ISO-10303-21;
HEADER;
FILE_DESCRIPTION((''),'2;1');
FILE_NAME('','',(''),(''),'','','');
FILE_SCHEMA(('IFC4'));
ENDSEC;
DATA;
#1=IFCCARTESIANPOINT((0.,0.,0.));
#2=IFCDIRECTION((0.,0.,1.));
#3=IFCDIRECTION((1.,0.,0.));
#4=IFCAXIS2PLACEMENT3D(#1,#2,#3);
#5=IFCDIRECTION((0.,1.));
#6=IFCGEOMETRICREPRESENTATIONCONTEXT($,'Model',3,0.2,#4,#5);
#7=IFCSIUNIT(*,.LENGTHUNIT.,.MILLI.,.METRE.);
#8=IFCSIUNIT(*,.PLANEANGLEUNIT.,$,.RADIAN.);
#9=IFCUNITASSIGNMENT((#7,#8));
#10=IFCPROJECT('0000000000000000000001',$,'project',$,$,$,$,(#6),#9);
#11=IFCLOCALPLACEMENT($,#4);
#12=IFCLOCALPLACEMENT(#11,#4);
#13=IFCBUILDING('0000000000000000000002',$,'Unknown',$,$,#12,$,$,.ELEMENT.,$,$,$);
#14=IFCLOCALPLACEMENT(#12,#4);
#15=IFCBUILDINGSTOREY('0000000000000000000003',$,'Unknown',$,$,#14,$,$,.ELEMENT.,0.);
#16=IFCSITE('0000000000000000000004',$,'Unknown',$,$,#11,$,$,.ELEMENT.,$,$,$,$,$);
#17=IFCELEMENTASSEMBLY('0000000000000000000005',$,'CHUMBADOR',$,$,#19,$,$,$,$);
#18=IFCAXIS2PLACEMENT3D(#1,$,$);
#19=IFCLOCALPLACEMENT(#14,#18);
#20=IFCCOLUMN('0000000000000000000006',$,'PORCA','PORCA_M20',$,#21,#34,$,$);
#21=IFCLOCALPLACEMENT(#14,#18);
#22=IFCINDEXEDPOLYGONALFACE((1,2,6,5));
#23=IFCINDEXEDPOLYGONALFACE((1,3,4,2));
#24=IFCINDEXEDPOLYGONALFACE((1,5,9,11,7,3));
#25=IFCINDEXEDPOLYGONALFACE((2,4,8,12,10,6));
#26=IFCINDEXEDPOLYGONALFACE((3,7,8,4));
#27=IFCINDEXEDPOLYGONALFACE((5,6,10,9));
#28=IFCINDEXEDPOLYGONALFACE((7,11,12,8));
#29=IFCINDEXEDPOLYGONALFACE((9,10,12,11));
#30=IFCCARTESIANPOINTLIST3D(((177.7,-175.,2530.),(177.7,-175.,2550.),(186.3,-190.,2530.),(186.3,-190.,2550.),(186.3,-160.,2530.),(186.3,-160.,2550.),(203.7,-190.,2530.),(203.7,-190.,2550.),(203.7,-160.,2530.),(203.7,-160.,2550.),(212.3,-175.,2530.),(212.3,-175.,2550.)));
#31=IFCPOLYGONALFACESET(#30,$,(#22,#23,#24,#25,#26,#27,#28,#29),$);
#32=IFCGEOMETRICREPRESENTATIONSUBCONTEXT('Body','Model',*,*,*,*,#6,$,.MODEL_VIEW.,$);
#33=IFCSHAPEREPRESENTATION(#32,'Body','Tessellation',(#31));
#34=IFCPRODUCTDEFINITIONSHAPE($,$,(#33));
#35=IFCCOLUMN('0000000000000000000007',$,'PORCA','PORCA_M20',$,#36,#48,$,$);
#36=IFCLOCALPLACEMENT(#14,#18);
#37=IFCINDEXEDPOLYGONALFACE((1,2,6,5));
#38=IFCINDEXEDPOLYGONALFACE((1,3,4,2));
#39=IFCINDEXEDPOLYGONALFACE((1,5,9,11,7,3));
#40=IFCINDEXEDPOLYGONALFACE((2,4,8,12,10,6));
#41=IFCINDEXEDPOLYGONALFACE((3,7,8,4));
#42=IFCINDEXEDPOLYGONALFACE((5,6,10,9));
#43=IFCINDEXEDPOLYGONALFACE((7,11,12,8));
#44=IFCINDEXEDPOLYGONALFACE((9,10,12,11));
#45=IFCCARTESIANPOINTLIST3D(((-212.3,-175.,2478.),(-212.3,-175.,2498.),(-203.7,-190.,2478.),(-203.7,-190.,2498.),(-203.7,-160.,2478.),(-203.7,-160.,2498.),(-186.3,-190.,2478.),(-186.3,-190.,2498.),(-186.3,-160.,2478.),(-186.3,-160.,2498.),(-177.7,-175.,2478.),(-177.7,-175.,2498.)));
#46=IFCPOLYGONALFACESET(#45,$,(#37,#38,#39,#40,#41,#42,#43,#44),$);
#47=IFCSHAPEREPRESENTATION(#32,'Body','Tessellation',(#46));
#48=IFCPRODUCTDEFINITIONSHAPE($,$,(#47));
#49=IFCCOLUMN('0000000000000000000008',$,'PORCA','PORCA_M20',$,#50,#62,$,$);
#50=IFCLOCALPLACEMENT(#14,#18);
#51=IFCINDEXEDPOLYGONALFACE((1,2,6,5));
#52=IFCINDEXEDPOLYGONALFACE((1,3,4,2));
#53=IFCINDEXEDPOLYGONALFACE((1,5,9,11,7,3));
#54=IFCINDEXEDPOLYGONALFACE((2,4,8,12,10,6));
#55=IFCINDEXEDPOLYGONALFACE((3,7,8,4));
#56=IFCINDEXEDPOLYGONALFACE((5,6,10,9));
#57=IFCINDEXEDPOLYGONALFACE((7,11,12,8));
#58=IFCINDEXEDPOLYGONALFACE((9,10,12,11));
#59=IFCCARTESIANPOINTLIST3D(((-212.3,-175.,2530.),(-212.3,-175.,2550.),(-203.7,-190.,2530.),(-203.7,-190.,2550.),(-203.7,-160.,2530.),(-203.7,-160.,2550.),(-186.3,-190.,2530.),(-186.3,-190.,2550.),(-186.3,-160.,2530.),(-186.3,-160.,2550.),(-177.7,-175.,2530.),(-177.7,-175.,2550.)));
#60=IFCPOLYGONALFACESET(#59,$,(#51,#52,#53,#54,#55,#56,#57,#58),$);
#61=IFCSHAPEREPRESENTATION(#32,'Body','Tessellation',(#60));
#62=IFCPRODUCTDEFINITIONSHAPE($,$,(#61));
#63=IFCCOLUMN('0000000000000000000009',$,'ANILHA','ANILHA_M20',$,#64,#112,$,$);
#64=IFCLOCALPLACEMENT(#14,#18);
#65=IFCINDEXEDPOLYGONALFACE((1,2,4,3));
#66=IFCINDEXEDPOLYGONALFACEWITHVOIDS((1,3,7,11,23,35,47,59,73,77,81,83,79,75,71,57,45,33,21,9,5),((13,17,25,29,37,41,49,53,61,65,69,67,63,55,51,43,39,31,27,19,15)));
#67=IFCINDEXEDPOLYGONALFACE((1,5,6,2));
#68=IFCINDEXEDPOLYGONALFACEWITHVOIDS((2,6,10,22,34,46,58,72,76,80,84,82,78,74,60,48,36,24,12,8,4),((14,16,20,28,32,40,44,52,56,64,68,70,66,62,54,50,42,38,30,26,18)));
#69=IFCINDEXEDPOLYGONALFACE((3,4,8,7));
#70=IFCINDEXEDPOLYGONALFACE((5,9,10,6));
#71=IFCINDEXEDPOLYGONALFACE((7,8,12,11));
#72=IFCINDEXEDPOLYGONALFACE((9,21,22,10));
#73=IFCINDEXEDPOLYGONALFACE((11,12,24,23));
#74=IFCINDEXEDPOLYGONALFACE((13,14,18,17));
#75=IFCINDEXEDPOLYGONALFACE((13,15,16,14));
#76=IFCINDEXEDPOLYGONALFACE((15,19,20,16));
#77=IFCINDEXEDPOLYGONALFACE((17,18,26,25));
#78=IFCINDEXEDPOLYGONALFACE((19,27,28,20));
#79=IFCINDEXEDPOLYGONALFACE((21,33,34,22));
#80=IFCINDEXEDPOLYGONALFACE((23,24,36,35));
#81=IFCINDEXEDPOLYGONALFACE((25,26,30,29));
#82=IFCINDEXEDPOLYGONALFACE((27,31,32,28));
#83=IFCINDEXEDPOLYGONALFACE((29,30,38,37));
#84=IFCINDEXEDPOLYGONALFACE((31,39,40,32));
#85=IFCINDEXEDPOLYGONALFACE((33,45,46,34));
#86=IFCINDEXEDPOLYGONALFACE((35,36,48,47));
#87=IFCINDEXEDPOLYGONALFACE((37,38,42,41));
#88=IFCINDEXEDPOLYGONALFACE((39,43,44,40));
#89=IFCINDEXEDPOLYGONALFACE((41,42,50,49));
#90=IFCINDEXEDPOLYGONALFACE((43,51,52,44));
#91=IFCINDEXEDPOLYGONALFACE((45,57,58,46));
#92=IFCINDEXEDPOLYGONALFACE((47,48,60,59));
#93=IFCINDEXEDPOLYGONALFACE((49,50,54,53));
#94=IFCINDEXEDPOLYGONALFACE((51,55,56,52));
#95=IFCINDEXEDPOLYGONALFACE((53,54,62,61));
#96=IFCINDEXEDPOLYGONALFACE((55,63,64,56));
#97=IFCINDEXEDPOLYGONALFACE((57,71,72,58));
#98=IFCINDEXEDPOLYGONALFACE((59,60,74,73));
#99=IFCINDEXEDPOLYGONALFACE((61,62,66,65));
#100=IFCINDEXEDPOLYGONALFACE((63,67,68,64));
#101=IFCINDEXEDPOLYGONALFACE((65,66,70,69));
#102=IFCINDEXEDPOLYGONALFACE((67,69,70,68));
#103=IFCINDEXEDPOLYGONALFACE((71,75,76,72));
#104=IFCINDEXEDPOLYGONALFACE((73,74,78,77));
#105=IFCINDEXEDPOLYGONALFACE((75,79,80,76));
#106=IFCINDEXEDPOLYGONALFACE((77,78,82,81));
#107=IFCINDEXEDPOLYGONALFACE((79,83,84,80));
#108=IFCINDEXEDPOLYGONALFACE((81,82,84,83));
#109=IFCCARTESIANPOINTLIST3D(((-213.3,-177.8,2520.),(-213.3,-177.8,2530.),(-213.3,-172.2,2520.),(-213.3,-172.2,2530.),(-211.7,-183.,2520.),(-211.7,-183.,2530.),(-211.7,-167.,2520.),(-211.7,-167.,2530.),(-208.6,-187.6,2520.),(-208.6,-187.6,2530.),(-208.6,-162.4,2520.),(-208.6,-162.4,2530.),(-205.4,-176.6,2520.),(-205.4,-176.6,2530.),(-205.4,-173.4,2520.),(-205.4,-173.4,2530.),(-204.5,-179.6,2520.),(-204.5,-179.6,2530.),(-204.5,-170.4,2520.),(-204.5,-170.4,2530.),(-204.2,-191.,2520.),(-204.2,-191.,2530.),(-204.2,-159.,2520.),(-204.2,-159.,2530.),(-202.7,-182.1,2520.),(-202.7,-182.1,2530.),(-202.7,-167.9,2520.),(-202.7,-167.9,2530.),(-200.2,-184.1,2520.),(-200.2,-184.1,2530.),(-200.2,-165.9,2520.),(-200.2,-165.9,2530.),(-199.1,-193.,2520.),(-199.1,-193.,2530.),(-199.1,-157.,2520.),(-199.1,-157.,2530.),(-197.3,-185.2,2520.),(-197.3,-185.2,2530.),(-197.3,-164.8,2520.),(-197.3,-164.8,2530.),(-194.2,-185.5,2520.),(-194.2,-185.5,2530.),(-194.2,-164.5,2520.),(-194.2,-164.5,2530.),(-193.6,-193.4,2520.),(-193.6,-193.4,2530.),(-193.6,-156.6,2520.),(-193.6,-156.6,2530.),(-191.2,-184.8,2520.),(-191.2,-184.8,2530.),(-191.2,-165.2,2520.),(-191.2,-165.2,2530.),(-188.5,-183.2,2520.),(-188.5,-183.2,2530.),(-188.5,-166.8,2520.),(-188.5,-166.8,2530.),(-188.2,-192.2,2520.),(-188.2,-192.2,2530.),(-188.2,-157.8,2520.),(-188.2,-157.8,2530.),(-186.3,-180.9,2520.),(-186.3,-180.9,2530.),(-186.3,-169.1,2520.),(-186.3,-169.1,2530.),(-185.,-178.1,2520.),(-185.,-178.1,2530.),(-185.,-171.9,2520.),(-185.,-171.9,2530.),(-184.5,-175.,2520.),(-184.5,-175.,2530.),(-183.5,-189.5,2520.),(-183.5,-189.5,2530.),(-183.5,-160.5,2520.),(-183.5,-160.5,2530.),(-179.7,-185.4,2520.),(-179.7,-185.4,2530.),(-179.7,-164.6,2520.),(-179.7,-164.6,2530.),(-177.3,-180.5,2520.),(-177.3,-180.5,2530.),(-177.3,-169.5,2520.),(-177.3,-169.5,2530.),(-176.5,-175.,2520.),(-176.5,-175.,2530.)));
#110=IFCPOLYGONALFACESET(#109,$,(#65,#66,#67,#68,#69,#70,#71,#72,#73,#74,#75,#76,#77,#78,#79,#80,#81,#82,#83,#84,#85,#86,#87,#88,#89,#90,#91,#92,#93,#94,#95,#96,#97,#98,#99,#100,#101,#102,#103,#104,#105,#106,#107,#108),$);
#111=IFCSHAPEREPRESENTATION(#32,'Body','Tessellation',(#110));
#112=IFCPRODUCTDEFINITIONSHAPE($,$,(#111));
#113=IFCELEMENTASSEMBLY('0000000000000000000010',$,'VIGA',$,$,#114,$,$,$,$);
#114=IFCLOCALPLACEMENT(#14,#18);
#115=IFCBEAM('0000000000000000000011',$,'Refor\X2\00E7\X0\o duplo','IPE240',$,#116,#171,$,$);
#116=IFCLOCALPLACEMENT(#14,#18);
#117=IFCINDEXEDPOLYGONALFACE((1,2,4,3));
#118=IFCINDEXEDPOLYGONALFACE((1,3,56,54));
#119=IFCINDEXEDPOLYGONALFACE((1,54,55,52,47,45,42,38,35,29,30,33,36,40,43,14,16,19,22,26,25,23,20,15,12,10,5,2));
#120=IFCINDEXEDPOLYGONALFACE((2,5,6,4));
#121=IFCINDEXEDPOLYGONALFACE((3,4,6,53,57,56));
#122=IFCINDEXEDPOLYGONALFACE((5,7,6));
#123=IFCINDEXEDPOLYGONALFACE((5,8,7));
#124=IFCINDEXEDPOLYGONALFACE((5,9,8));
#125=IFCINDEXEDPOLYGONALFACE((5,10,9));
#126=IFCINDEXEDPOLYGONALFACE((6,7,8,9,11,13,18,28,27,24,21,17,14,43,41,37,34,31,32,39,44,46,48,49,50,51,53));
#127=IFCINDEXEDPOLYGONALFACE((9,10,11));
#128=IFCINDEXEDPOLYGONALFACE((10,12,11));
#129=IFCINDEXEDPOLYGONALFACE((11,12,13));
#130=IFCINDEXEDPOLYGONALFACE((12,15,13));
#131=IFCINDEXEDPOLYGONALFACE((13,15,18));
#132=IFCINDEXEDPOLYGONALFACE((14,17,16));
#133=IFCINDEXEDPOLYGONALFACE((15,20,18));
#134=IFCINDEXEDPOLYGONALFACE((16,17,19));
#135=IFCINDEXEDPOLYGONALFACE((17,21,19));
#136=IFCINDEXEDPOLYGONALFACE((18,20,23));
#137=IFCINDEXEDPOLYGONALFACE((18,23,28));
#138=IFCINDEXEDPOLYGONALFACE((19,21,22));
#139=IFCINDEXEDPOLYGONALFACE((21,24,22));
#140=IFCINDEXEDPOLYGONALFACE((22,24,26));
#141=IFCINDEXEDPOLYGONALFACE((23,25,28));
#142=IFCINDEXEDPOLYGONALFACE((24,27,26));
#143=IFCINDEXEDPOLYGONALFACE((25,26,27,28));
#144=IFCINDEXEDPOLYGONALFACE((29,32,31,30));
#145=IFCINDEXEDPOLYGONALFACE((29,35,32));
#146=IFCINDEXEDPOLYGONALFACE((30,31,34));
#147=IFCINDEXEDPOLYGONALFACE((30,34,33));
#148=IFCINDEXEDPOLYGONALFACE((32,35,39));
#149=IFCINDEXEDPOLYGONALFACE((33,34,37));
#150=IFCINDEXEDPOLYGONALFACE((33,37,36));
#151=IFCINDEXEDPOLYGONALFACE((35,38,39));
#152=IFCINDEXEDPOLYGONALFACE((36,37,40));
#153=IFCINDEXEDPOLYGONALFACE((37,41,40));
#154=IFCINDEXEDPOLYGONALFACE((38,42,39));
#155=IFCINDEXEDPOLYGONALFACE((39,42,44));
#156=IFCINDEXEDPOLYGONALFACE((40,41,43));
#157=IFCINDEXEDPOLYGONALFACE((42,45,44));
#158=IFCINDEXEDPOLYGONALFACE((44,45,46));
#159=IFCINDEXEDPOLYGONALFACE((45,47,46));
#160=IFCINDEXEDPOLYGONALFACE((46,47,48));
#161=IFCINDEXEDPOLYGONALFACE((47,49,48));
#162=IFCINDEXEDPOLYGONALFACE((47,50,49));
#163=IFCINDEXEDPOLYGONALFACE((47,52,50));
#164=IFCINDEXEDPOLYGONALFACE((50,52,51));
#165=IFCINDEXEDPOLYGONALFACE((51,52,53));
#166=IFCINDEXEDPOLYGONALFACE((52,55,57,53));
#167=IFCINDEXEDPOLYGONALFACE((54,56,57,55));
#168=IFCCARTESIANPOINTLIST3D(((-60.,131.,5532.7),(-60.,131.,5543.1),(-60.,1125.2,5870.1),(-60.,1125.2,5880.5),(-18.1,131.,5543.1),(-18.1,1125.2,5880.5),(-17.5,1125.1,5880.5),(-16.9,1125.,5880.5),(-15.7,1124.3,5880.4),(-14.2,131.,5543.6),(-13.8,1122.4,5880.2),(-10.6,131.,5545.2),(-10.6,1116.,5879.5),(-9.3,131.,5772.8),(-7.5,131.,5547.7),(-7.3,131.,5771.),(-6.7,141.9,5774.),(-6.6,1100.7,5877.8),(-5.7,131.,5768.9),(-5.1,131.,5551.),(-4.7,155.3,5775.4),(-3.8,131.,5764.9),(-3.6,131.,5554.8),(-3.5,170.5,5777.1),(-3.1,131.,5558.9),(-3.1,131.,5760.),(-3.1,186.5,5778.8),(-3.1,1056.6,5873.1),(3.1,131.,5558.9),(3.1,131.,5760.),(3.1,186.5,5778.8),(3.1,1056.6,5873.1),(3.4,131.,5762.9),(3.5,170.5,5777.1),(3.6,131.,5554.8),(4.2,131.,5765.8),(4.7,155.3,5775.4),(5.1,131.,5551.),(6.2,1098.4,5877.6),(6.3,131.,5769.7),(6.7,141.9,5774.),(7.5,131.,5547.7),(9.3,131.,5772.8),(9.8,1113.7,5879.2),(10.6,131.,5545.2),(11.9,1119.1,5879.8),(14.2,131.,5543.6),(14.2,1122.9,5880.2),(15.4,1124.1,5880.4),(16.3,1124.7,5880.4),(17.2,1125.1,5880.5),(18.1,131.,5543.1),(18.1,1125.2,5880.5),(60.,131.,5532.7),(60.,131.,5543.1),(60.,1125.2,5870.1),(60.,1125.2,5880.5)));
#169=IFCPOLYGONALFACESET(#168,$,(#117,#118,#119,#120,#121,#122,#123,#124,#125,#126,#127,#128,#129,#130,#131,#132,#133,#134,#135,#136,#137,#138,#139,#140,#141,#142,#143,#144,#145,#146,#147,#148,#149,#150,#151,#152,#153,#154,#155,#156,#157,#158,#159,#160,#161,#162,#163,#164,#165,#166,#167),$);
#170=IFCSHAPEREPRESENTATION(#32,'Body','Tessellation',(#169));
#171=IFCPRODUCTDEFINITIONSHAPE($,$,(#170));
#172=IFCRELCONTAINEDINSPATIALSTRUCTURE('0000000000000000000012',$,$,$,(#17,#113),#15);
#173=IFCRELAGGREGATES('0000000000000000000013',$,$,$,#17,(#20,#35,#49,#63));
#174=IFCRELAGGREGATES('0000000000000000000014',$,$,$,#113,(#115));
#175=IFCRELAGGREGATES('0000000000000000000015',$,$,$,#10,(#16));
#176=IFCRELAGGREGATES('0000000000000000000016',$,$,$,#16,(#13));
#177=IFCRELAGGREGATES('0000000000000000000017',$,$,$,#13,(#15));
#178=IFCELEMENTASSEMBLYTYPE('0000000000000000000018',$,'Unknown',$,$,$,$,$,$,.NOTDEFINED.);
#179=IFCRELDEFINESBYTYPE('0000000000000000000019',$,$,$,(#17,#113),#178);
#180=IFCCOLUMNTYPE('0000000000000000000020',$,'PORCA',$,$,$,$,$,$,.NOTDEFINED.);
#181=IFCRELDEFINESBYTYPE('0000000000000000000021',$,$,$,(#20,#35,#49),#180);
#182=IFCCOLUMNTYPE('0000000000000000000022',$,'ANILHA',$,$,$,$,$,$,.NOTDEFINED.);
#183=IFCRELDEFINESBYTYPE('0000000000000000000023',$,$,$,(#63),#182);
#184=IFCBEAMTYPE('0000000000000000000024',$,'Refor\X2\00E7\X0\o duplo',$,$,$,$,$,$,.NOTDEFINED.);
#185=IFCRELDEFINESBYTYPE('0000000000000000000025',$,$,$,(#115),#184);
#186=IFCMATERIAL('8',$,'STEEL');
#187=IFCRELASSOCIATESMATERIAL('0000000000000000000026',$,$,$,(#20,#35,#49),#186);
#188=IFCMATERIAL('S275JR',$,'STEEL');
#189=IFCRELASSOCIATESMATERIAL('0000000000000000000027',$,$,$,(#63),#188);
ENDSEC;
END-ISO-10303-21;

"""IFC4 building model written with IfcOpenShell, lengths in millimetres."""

from ifc_helpers import new_model, si_unit, direction, frame, origin_with_axes, origin_2d_with_axis, place, context, subcontext, project, spatial, polyline, hollow_circle, i_section, outline, extrude, clip, halfspace, material, material_profile, profile_set, profile_usage, type_object, element, aggregate, save


model = new_model("IFC4")

# Units and contexts
model_context = context("Model", 3, precision=0.2, world=origin_with_axes(), true_north=direction((0.0, 1.0)))
body_context = subcontext(model_context, "Body", "Model", "MODEL_VIEW")
ifc_project = project(units=[si_unit("LENGTHUNIT", "METRE", prefix="MILLI"), si_unit("PLANEANGLEUNIT", "RADIAN")], contexts=[model_context])

# Site, building, storey
site_placement = place(None, origin_with_axes())
site = spatial("IfcSite", under=ifc_project, at=site_placement, Name="Unknown", CompositionType="ELEMENT")
building_placement = place(site_placement, origin_with_axes())
building = spatial("IfcBuilding", under=site, at=building_placement, Name="Unknown", CompositionType="ELEMENT")
storey_placement = place(building_placement, origin_with_axes())
storey = spatial("IfcBuildingStorey", under=building, at=storey_placement, Name="Unknown", CompositionType="ELEMENT", Elevation=0.0)

# Shared definitions
element_assembly_type = type_object("IfcElementAssemblyType", Name="Unknown", PredefinedType="NOTDEFINED")

# Element assembly, columns
assembly_1_placement = place(storey_placement, frame((-195.0, -175.0, 2445.0), z_axis=(1.0, 0.0, 0.0), x_axis=(0.0, 0.0, -1.0)))
assembly_1 = element("IfcElementAssembly", 1, at=assembly_1_placement, inside=storey, type_object=element_assembly_type, Name="CHUMBADOR")
ifc_material_1 = material(Name="8", Category="STEEL")
ifc_material_profile_1 = material_profile(ifc_material_1, outline(polyline([(8.7, -15.0), (17.3, 0.0), (8.7, 15.0), (-8.7, 15.0), (-17.3, 0.0), (-8.7, -15.0), (8.7, -15.0)])), Name="PORCA_M20")
ifc_profile_set_1 = profile_set([ifc_material_profile_1])
ifc_profile_usage_1 = profile_usage(ifc_profile_set_1, cardinal=5)
column_type_1 = type_object("IfcColumnType", Name="PORCA", PredefinedType="NOTDEFINED")
column_1_placement = place(assembly_1_placement, frame((-105.0, 0.0, 390.0), z_axis=(0.0, 0.0, 1.0), x_axis=(1.0, 0.0, 0.0)))
column_1 = element("IfcColumn", 2, at=column_1_placement, type_object=column_type_1, material=ifc_profile_usage_1, Name="PORCA", Description="PORCA_M20", context=body_context, shape_type="SolidModel", body=[
    extrude(outline(polyline([(8.7, -15.0), (17.3, 0.0), (8.7, 15.0), (-8.7, 15.0), (-17.3, 0.0), (-8.7, -15.0), (8.7, -15.0)])), frame((0.0, 0.0, 0.0), z_axis=(-1.0, 0.0, 0.0), x_axis=(0.0, 0.0, 1.0)), (0.0, 0.0, -1.0), 20.0),
])
column_2_placement = place(assembly_1_placement, frame((-53.0, 0.0, 0.0), z_axis=(0.0, 0.0, -1.0), x_axis=(1.0, 0.0, 0.0)))
column_2 = element("IfcColumn", 3, at=column_2_placement, type_object=column_type_1, material=ifc_profile_usage_1, Name="PORCA", Description="PORCA_M20", context=body_context, shape_type="SolidModel", body=[
    extrude(outline(polyline([(8.7, -15.0), (17.3, 0.0), (8.7, 15.0), (-8.7, 15.0), (-17.3, 0.0), (-8.7, -15.0), (8.7, -15.0)])), frame((0.0, 0.0, 0.0), z_axis=(-1.0, 0.0, 0.0), x_axis=(0.0, 0.0, 1.0)), (0.0, 0.0, -1.0), 20.0),
])
column_3_placement = place(assembly_1_placement, frame((-105.0, 0.0, 0.0), z_axis=(0.0, 0.0, -1.0), x_axis=(1.0, 0.0, 0.0)))
column_3 = element("IfcColumn", 4, at=column_3_placement, type_object=column_type_1, material=ifc_profile_usage_1, Name="PORCA", Description="PORCA_M20", context=body_context, shape_type="SolidModel", body=[
    extrude(outline(polyline([(8.7, -15.0), (17.3, 0.0), (8.7, 15.0), (-8.7, 15.0), (-17.3, 0.0), (-8.7, -15.0), (8.7, -15.0)])), frame((0.0, 0.0, 0.0), z_axis=(-1.0, 0.0, 0.0), x_axis=(0.0, 0.0, 1.0)), (0.0, 0.0, -1.0), 20.0),
])
ifc_material_2 = material(Name="S275JR", Category="STEEL")
ifc_material_profile_2 = material_profile(ifc_material_2, hollow_circle(Radius=18.5, WallThickness=8.0, at=origin_2d_with_axis()), Name="ANILHA_M20")
ifc_profile_set_2 = profile_set([ifc_material_profile_2])
ifc_profile_usage_2 = profile_usage(ifc_profile_set_2, cardinal=5)
column_type_2 = type_object("IfcColumnType", Name="ANILHA", PredefinedType="NOTDEFINED")
column_4_placement = place(assembly_1_placement, frame((-85.0, 0.0, 0.0), z_axis=(0.0, 0.0, 1.0), x_axis=(1.0, 0.0, 0.0)))
column_4 = element("IfcColumn", 5, at=column_4_placement, type_object=column_type_2, material=ifc_profile_usage_2, Name="ANILHA", Description="ANILHA_M20", context=body_context, shape_type="SolidModel", body=[
    extrude(hollow_circle(Radius=18.5, WallThickness=8.0, at=origin_2d_with_axis()), frame((0.0, 0.0, 0.0), z_axis=(-1.0, 0.0, 0.0), x_axis=(0.0, 0.0, 1.0)), (0.0, 0.0, -1.0), 10.0),
])
aggregate(assembly_1, [column_1, column_2, column_3, column_4])

# Element assembly, beam
assembly_2_placement = place(storey_placement, frame((0.0, 12.9, 5880.7), z_axis=(1.0, 0.0, 0.0), x_axis=(0.0, 0.994183, 0.107703)))
assembly_2 = element("IfcElementAssembly", 6, at=assembly_2_placement, inside=storey, type_object=element_assembly_type, Name="VIGA")
beam_type_1 = type_object("IfcBeamType", Name="Reforço duplo", PredefinedType="NOTDEFINED")
beam_1_placement = place(assembly_2_placement, frame((53.8, -241.6, 0.0), z_axis=(0.0, 0.0, 1.0), x_axis=(0.976051, 0.217543, 0.0)))
beam_1 = element("IfcBeam", 7, at=beam_1_placement, type_object=beam_type_1, Name="Reforço duplo", Description="IPE240", context=body_context, shape_type="Clipping", body=[
    clip(clip(clip(extrude(i_section(OverallWidth=120.0, OverallDepth=240.0, WebThickness=6.2, FlangeThickness=9.8, FilletRadius=15.0, FlangeEdgeRadius=0.0, FlangeSlope=0.0, at=origin_2d_with_axis()), frame((-199.3, 0.0, 0.0), z_axis=(-1.0, 0.0, 0.0), x_axis=(0.0, 0.0, 1.0)), (0.0, 0.0, -1.0), 1529.9), halfspace(frame((476.2, 1282.9, 0.0), z_axis=(-0.946943, 0.321401, 0.0), x_axis=(-0.321401, -0.946943, 0.0)), False)), halfspace(frame((20.4, 120.0, -60.0), z_axis=(0.217543, 0.976051, 0.0), x_axis=(0.0, 0.0, 1.0)), False)), halfspace(frame((1049.9, -120.0, 0.0), z_axis=(0.946943, -0.321401, 0.0), x_axis=(0.321401, 0.946943, 0.0)), False)),
])

aggregate(assembly_2, [beam_1])

save(model, "model.ifc")
